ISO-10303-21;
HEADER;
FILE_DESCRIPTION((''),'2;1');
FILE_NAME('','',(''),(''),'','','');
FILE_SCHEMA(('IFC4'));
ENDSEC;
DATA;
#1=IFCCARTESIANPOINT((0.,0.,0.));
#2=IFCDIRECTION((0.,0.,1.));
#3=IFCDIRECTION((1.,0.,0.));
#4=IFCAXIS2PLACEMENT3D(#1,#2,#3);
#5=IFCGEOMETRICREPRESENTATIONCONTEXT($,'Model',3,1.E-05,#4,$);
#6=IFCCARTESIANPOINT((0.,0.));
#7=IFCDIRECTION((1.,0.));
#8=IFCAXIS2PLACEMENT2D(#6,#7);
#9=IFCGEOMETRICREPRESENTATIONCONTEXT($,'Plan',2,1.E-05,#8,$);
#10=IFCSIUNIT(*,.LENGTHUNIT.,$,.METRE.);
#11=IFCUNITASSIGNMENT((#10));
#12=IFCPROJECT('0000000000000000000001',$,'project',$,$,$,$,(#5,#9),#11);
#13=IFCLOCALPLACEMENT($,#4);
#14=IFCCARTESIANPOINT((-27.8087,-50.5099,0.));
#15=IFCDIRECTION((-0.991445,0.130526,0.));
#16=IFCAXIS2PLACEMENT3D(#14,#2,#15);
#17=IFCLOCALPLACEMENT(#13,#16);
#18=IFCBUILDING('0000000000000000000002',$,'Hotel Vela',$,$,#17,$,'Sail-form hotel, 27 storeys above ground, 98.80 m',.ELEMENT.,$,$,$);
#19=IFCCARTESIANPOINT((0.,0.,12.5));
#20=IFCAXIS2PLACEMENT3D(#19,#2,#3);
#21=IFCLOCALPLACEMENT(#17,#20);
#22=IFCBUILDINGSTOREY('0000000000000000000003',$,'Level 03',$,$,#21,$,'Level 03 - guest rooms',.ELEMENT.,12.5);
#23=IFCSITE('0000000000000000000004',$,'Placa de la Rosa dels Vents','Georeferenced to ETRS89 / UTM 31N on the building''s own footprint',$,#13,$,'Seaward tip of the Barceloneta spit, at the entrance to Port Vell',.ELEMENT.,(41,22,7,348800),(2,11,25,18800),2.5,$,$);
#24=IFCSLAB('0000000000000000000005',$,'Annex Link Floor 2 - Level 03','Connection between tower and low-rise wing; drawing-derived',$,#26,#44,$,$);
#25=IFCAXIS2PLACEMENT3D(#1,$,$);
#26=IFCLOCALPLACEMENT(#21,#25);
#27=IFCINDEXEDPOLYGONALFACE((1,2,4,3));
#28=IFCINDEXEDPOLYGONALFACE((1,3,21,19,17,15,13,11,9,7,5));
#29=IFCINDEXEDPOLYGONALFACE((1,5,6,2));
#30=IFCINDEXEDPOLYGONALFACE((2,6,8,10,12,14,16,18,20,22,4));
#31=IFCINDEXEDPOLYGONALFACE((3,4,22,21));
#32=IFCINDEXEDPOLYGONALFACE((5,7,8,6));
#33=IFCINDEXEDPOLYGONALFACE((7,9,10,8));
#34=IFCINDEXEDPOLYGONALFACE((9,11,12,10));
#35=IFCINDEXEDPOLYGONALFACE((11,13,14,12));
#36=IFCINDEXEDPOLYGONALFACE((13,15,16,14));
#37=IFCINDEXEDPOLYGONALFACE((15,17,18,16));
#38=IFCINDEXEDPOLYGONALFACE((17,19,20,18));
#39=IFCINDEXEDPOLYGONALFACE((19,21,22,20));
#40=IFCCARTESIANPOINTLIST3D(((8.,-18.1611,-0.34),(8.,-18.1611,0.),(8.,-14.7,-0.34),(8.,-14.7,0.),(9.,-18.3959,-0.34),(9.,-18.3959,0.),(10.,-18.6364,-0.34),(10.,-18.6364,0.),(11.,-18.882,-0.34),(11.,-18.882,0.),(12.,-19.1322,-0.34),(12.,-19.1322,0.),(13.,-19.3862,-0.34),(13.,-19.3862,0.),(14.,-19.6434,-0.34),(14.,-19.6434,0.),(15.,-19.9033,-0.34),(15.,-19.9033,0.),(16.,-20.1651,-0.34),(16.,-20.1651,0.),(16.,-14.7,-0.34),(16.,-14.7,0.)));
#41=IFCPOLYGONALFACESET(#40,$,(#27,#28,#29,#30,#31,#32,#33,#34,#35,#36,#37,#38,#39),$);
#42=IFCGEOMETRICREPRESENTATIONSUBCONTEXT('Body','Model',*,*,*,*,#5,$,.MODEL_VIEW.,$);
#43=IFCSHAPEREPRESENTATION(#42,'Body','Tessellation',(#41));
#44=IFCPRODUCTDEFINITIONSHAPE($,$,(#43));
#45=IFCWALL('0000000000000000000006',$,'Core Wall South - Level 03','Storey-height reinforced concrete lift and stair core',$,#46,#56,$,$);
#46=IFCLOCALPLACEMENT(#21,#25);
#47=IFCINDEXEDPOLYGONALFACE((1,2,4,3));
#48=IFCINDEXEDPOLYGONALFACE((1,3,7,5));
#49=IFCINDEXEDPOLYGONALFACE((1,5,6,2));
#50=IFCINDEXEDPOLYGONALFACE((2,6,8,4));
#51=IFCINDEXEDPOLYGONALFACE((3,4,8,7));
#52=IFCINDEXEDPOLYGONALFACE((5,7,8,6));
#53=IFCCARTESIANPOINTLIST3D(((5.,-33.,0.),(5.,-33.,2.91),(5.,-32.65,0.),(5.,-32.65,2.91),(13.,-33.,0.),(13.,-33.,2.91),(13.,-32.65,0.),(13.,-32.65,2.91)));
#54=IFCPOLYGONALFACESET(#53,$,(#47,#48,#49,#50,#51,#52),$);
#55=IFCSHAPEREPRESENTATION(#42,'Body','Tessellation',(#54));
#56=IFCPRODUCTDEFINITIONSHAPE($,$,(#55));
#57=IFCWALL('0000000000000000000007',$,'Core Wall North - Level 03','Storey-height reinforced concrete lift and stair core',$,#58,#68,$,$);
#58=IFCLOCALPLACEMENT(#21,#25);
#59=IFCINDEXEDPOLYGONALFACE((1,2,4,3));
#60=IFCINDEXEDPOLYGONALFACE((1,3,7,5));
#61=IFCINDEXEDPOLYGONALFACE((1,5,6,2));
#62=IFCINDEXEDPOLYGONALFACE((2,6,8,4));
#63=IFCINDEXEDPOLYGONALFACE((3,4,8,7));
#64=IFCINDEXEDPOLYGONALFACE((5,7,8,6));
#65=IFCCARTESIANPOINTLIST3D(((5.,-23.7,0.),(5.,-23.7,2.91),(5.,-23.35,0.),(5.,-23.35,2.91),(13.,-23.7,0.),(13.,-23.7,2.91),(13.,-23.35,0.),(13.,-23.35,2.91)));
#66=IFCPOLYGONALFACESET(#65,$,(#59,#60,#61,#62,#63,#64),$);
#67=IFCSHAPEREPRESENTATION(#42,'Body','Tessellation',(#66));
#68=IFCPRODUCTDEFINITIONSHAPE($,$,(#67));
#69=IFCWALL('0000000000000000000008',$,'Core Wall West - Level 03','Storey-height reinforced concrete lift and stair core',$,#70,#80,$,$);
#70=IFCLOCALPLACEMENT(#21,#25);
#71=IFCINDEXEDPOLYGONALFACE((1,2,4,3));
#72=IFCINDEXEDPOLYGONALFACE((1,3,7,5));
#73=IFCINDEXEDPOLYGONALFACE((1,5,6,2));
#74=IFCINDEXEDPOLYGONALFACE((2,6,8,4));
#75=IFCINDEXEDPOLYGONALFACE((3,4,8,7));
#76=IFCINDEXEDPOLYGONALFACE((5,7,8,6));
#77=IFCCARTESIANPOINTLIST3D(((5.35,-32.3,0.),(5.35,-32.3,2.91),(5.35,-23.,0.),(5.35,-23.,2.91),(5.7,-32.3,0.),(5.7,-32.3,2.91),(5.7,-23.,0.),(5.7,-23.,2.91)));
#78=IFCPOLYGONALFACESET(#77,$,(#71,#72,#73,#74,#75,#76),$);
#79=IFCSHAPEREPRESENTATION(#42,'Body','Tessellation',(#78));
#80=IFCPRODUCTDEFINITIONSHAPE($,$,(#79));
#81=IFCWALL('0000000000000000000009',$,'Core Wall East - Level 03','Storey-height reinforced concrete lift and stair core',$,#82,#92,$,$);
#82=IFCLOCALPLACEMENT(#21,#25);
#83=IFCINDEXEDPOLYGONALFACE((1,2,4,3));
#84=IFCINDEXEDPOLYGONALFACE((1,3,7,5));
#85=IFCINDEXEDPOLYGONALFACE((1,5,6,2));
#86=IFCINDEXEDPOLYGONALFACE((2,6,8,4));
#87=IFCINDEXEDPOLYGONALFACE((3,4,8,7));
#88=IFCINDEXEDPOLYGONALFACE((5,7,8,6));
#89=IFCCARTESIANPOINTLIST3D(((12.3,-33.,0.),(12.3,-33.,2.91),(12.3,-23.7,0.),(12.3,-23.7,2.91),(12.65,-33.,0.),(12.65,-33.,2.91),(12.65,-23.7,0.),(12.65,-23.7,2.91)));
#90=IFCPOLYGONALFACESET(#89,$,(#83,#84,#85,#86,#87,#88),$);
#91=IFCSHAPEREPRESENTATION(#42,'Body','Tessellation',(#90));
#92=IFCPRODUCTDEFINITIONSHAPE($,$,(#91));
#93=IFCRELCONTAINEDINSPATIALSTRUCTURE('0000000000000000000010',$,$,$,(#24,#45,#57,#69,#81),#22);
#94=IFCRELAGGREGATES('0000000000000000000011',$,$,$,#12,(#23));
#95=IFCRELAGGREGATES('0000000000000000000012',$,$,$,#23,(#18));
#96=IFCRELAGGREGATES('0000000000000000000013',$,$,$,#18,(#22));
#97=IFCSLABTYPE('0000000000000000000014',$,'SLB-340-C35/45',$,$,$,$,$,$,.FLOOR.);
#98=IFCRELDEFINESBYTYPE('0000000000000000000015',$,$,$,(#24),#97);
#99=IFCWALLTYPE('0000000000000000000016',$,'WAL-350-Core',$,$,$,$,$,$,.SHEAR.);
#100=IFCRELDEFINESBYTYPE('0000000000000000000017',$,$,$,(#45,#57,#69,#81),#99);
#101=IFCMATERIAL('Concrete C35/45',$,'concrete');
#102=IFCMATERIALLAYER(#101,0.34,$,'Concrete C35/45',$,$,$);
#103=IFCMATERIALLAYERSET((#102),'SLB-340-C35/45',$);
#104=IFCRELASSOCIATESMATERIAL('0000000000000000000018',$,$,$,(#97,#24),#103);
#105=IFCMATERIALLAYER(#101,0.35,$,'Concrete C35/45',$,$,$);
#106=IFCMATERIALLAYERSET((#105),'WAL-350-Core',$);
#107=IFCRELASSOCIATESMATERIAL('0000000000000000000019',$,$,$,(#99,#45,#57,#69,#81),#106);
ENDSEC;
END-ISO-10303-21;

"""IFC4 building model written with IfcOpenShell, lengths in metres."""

from ifc_helpers import new_model, si_unit, frame, origin_with_axes, origin_2d_with_axis, place, context, subcontext, project, spatial, line, indexed_curve, outline, extrude, material, layer, layer_set, layer_usage, type_object, element, save


model = new_model("IFC4")

# Units and contexts
model_context = context("Model", 3, precision=1e-05, world=origin_with_axes())
plan_context = context("Plan", 2, precision=1e-05, world=origin_2d_with_axis())
body_context = subcontext(model_context, "Body", "Model", "MODEL_VIEW")
ifc_project = project(units=[si_unit("LENGTHUNIT", "METRE")], contexts=[model_context, plan_context])

# Site, building, storey
site_placement = place(None, origin_with_axes())
site = spatial("IfcSite", under=ifc_project, at=site_placement, Name="Placa de la Rosa dels Vents", Description="Georeferenced to ETRS89 / UTM 31N on the building's own footprint", LongName="Seaward tip of the Barceloneta spit, at the entrance to Port Vell", CompositionType="ELEMENT", RefLatitude=(41, 22, 7, 348800), RefLongitude=(2, 11, 25, 18800), RefElevation=2.5)
building_placement = place(site_placement, frame((-27.8087, -50.5099, 0.0), z_axis=(0.0, 0.0, 1.0), x_axis=(-0.991445, 0.130526, 0.0)))
building = spatial("IfcBuilding", under=site, at=building_placement, Name="Hotel Vela", LongName="Sail-form hotel, 27 storeys above ground, 98.80 m", CompositionType="ELEMENT")
storey_placement = place(building_placement, frame((0.0, 0.0, 12.5), z_axis=(0.0, 0.0, 1.0), x_axis=(1.0, 0.0, 0.0)))
storey = spatial("IfcBuildingStorey", under=building, at=storey_placement, Name="Level 03", LongName="Level 03 - guest rooms", CompositionType="ELEMENT", Elevation=12.5)

# Shared definitions
ifc_material = material(Name="Concrete C35/45", Category="concrete")

# Shared definitions
ifc_layer_1 = layer(ifc_material, 0.34, Name="Concrete C35/45")
ifc_layer_set_1 = layer_set([ifc_layer_1], Name="SLB-340-C35/45")
slab_type = type_object("IfcSlabType", Name="SLB-340-C35/45", PredefinedType="FLOOR", material=ifc_layer_set_1)

# Slab
ifc_layer_usage_1 = layer_usage(ifc_layer_set_1, "AXIS3", "POSITIVE", 0.0)
slab_1_placement = place(storey_placement, frame((0.0, 0.0, -0.34), z_axis=(0.0, 0.0, 1.0), x_axis=(1.0, 0.0, 0.0)))
element("IfcSlab", 1, at=slab_1_placement, inside=storey, type_object=slab_type, material=ifc_layer_usage_1, Name="Annex Link Floor 2 - Level 03", Description="Connection between tower and low-rise wing; drawing-derived", context=body_context, shape_type="SweptSolid", body=[
    extrude(outline(indexed_curve([(8.0, -18.1611), (9.0, -18.3959), (10.0, -18.6364), (11.0, -18.882), (12.0, -19.1322), (13.0, -19.3862), (14.0, -19.6434), (15.0, -19.9033), (16.0, -20.1651), (16.0, -14.7), (8.0, -14.7)], segments=[line(1, 2, 3, 4, 5, 6, 7, 8, 9, 10, 11, 1)])), origin_with_axes(), (0.0, 0.0, 1.0), 0.34),
])

# Walls
ifc_layer_2 = layer(ifc_material, 0.35, Name="Concrete C35/45")
ifc_layer_set_2 = layer_set([ifc_layer_2], Name="WAL-350-Core")
ifc_layer_usage_2 = layer_usage(ifc_layer_set_2, "AXIS2", "POSITIVE", 0.0)
wall_type = type_object("IfcWallType", Name="WAL-350-Core", PredefinedType="SHEAR", material=ifc_layer_set_2)
wall_1_placement = place(storey_placement, frame((5.0, -33.0, 0.0), z_axis=(0.0, 0.0, 1.0), x_axis=(1.0, 0.0, 0.0)))
element("IfcWall", 2, at=wall_1_placement, inside=storey, type_object=wall_type, material=ifc_layer_usage_2, Name="Core Wall South - Level 03", Description="Storey-height reinforced concrete lift and stair core", context=body_context, shape_type="SweptSolid", body=[
    extrude(outline(indexed_curve([(0.0, 0.0), (8.0, 0.0), (8.0, 0.35), (0.0, 0.35)], segments=[line(1, 2, 3, 4, 1)])), origin_with_axes(), (0.0, 0.0, 1.0), 2.91),
])
ifc_layer_usage_3 = layer_usage(ifc_layer_set_2, "AXIS2", "POSITIVE", 0.0)
wall_2_placement = place(storey_placement, frame((13.0, -23.35, 0.0), z_axis=(0.0, 0.0, 1.0), x_axis=(-1.0, 0.0, 0.0)))
element("IfcWall", 3, at=wall_2_placement, inside=storey, type_object=wall_type, material=ifc_layer_usage_3, Name="Core Wall North - Level 03", Description="Storey-height reinforced concrete lift and stair core", context=body_context, shape_type="SweptSolid", body=[
    extrude(outline(indexed_curve([(0.0, 0.0), (8.0, 0.0), (8.0, 0.35), (0.0, 0.35)], segments=[line(1, 2, 3, 4, 1)])), origin_with_axes(), (0.0, 0.0, 1.0), 2.91),
])
ifc_layer_usage_4 = layer_usage(ifc_layer_set_2, "AXIS2", "POSITIVE", 0.0)
wall_3_placement = place(storey_placement, frame((5.35, -23.0, 0.0), z_axis=(0.0, 0.0, 1.0), x_axis=(0.0, -1.0, 0.0)))
element("IfcWall", 4, at=wall_3_placement, inside=storey, type_object=wall_type, material=ifc_layer_usage_4, Name="Core Wall West - Level 03", Description="Storey-height reinforced concrete lift and stair core", context=body_context, shape_type="SweptSolid", body=[
    extrude(outline(indexed_curve([(0.0, 0.0), (9.3, 0.0), (9.3, 0.35), (0.0, 0.35)], segments=[line(1, 2, 3, 4, 1)])), origin_with_axes(), (0.0, 0.0, 1.0), 2.91),
])
ifc_layer_usage_5 = layer_usage(ifc_layer_set_2, "AXIS2", "POSITIVE", 0.0)
wall_4_placement = place(storey_placement, frame((12.65, -33.0, 0.0), z_axis=(0.0, 0.0, 1.0), x_axis=(0.0, 1.0, 0.0)))
element("IfcWall", 5, at=wall_4_placement, inside=storey, type_object=wall_type, material=ifc_layer_usage_5, Name="Core Wall East - Level 03", Description="Storey-height reinforced concrete lift and stair core", context=body_context, shape_type="SweptSolid", body=[
    extrude(outline(indexed_curve([(0.0, 0.0), (9.3, 0.0), (9.3, 0.35), (0.0, 0.35)], segments=[line(1, 2, 3, 4, 1)])), origin_with_axes(), (0.0, 0.0, 1.0), 2.91),
])

save(model, "model.ifc")
